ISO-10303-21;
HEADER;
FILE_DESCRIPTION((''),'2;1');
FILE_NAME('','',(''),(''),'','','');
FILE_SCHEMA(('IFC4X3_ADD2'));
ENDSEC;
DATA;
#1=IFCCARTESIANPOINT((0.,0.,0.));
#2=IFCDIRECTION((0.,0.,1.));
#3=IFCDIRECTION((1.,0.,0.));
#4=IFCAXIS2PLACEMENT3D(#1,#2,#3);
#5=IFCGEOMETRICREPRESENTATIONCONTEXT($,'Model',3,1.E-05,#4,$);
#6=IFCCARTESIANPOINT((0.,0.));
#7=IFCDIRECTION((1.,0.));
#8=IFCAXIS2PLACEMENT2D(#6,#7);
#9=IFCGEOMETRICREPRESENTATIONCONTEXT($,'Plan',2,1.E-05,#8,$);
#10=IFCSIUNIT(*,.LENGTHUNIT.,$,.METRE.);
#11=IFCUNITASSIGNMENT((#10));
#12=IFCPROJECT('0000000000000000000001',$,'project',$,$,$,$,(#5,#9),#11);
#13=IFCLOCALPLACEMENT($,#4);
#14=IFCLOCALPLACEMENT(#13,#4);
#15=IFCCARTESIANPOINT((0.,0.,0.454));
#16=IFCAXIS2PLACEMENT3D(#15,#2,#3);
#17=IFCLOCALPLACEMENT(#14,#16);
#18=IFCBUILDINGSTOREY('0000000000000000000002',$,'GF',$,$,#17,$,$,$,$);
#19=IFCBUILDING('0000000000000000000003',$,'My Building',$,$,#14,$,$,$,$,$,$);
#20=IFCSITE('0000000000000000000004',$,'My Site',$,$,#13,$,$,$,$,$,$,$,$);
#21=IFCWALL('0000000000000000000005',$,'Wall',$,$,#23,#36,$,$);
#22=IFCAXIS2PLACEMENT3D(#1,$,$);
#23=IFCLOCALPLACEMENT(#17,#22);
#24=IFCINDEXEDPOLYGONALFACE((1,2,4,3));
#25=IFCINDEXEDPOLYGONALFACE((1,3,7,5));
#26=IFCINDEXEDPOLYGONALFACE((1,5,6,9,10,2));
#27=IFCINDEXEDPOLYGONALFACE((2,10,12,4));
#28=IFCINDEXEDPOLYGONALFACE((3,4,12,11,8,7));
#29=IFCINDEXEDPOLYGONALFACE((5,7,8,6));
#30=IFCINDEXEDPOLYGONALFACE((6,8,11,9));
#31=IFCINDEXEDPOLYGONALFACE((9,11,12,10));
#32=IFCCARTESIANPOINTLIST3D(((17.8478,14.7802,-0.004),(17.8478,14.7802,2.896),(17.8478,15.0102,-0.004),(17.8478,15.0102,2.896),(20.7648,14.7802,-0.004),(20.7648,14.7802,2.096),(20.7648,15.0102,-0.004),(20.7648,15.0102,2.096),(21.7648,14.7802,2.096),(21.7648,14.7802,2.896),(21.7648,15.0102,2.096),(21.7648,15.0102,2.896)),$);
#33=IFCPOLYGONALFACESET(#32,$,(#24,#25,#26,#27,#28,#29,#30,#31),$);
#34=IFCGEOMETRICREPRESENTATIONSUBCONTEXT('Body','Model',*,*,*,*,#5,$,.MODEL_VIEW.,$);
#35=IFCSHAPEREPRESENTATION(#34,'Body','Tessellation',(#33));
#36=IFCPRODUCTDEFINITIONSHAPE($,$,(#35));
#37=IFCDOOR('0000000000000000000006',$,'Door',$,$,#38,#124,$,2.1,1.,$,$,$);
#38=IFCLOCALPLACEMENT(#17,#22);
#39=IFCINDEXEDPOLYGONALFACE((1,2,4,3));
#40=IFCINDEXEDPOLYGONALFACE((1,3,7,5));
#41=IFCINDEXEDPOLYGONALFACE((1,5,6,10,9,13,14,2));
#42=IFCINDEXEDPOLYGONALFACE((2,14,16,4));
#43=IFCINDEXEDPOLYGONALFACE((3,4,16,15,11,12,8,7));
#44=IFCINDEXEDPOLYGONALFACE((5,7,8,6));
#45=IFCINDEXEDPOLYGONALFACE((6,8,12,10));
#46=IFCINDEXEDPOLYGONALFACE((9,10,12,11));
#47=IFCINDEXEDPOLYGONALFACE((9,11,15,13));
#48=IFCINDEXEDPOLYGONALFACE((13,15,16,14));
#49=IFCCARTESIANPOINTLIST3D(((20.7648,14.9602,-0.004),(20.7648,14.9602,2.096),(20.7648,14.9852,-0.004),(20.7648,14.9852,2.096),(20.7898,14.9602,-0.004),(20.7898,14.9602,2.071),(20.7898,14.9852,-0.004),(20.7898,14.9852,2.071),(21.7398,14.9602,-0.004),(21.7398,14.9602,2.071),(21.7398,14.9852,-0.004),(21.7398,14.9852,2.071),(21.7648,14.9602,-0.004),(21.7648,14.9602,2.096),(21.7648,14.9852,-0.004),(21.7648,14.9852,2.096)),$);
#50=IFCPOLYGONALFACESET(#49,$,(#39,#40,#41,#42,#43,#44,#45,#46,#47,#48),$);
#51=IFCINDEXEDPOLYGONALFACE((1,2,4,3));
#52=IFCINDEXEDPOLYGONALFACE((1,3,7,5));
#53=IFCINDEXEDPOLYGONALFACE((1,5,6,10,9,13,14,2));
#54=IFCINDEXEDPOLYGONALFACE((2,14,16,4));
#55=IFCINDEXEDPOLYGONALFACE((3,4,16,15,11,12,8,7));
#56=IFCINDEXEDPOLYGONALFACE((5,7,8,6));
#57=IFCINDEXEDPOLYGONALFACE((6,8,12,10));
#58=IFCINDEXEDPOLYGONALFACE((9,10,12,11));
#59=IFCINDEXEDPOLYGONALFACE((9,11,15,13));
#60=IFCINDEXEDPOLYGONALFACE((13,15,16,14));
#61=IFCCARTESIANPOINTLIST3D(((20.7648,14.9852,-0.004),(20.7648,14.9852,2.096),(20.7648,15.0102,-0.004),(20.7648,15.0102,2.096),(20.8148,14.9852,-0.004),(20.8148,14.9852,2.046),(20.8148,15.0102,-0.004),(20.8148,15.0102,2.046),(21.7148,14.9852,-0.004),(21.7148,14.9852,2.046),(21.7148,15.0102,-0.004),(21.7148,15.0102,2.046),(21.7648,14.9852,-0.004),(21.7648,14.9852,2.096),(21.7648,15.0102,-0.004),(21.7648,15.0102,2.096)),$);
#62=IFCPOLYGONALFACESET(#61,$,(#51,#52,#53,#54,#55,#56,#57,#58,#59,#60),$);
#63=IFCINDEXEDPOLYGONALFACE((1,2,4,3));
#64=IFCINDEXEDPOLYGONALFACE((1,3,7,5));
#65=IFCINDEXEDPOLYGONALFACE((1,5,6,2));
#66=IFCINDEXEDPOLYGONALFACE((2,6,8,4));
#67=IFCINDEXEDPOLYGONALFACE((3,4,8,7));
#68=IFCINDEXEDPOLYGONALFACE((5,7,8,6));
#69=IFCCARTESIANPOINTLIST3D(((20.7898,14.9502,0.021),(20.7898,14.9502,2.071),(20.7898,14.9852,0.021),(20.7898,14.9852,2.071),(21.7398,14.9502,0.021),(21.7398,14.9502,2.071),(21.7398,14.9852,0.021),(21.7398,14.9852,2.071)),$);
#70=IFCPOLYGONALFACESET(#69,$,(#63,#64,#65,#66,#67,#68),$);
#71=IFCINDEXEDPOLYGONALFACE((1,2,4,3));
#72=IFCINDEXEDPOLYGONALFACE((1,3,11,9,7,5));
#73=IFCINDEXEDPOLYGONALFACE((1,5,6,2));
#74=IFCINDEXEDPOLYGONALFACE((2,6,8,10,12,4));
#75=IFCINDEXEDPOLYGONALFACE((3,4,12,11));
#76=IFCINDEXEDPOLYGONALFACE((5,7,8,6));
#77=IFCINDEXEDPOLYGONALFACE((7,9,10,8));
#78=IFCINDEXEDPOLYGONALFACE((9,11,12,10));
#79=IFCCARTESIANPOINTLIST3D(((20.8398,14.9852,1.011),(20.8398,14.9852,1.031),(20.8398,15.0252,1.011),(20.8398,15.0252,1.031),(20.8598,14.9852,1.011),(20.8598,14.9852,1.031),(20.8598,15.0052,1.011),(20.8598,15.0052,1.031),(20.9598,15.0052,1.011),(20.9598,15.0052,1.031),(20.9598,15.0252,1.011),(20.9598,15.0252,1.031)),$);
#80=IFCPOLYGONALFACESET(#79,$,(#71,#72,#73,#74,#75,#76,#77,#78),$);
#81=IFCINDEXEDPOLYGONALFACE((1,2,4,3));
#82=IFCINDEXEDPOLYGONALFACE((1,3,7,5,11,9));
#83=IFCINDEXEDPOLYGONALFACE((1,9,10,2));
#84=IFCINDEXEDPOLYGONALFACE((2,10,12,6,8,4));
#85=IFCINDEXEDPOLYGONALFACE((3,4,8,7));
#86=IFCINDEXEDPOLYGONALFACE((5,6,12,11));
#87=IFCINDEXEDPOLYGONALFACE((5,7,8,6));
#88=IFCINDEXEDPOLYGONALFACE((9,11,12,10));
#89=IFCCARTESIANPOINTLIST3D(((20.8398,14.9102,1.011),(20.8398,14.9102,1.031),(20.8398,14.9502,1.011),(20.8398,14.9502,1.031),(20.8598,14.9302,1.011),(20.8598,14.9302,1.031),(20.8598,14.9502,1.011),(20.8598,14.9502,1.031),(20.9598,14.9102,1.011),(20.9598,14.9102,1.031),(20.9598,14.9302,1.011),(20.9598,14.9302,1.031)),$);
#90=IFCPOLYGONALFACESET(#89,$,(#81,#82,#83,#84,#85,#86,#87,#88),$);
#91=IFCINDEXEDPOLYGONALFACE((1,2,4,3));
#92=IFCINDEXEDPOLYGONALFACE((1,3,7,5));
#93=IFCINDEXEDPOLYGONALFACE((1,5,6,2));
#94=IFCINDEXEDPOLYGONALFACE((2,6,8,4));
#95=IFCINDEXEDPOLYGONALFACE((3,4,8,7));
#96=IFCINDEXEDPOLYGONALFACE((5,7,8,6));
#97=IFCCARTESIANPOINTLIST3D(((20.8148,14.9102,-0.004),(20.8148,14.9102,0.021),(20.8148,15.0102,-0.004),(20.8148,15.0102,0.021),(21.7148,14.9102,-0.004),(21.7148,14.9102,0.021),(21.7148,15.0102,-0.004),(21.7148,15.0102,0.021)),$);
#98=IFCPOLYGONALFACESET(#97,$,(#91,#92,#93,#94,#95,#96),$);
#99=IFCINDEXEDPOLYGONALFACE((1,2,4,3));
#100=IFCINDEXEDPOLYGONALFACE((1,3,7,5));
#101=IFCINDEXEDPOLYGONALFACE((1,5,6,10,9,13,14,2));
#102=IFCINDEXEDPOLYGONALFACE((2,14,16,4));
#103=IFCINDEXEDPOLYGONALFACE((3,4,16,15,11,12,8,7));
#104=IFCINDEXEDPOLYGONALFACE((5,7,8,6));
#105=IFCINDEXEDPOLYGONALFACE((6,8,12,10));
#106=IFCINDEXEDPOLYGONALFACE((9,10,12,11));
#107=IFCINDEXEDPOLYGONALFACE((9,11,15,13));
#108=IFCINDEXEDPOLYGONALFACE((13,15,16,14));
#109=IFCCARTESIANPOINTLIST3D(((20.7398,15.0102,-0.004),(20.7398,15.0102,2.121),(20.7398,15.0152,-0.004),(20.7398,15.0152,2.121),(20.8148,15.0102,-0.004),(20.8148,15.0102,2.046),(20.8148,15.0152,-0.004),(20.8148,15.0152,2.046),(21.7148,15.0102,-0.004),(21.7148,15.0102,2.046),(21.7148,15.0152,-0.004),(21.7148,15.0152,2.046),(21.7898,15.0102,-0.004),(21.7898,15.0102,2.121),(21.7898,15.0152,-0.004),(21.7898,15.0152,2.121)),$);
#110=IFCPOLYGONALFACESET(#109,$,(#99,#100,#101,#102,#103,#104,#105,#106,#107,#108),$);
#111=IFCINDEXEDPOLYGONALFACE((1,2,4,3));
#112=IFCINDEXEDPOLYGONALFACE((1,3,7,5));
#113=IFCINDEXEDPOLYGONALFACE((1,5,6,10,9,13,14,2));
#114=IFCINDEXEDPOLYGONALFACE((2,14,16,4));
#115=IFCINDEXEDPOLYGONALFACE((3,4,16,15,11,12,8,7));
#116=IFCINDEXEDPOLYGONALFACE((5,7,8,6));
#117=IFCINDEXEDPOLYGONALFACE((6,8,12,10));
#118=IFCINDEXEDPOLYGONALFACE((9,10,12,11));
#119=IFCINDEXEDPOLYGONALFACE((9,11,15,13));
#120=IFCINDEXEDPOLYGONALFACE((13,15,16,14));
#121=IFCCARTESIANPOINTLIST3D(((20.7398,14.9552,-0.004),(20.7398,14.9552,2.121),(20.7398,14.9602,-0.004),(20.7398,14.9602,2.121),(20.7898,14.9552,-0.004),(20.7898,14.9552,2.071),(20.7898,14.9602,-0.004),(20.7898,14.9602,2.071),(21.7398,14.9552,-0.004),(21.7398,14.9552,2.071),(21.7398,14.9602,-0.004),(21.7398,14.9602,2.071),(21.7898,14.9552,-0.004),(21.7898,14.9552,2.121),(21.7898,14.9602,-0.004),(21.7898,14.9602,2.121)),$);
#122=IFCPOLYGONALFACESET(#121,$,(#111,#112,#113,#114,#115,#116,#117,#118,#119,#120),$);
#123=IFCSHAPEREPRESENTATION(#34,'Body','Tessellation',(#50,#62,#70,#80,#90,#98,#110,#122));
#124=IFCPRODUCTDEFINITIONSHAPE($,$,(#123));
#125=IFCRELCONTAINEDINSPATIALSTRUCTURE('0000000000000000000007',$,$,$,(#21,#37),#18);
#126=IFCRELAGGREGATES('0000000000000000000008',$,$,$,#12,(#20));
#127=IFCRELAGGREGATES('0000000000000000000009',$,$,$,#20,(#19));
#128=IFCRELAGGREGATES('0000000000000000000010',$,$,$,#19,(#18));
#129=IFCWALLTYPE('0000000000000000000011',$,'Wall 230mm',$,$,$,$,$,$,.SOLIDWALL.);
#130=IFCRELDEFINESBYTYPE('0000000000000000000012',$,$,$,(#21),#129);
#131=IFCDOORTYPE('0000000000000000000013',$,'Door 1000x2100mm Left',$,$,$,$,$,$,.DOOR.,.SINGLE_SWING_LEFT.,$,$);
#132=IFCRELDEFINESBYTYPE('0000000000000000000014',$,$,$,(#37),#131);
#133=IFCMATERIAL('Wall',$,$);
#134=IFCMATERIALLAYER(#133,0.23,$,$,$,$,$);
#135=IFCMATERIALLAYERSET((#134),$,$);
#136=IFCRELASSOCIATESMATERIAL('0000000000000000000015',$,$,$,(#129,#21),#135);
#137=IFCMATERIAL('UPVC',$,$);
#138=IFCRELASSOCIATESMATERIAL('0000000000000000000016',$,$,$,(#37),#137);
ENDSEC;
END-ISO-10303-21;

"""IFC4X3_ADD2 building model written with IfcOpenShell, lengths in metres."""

from ifc_helpers import new_model, entity, si_unit, frame, origin_with_axes, origin_2d_with_axis, place, context, subcontext, project, spatial, line, indexed_curve, outline, extrude, shape, source, transform, mapped, material, layer, layer_set, layer_usage, type_object, type_shapes, element, fill, save


model = new_model("IFC4X3_ADD2")

# Units and contexts
model_context = context("Model", 3, precision=1e-05, world=origin_with_axes())
plan_context = context("Plan", 2, precision=1e-05, world=origin_2d_with_axis())
body_context_1 = subcontext(model_context, "Body", "Model", "MODEL_VIEW")
body_context_2 = subcontext(plan_context, "Body", "Plan", "PLAN_VIEW")
ifc_project = project(units=[si_unit("LENGTHUNIT", "METRE")], contexts=[model_context, plan_context])

# Site, building, storey
site_placement = place(None, origin_with_axes())
site = spatial("IfcSite", under=ifc_project, at=site_placement, Name="My Site")
building_placement = place(site_placement, origin_with_axes())
building = spatial("IfcBuilding", under=site, at=building_placement, Name="My Building")
storey_placement = place(building_placement, frame((0.0, 0.0, 0.454), z_axis=(0.0, 0.0, 1.0), x_axis=(1.0, 0.0, 0.0)))
storey = spatial("IfcBuildingStorey", under=building, at=storey_placement, Name="GF")

# Shared definitions
ifc_material_1 = material(Name="Wall")
ifc_material_2 = material(Name="UPVC")

# Shared definitions
shared_shape_1 = source(origin_with_axes(), body_context_1, "Body", "SweptSolid", [
    extrude(outline(indexed_curve([(0.0, 0.0), (1.0, 0.0), (1.0, 2.1), (0.0, 2.1)], segments=[line(1, 2, 3, 4, 1)])), frame((0.0, -0.6, 0.0), z_axis=(0.0, -1.0, 0.0), x_axis=(1.0, 0.0, 0.0)), (0.0, 0.0, -1.0), 1.2),
])
door_type_1 = type_object("IfcDoorType", Name="Door 1000x2100mm Left", OperationType="SINGLE_SWING_LEFT", PredefinedType="DOOR")
shared_shape_2 = source(origin_with_axes(), body_context_1, "Body", "SweptSolid", [
    extrude(outline(indexed_curve([(0.0, 0.0), (0.0, 2.1), (1.0, 2.1), (1.0, 0.0), (0.975, 0.0), (0.975, 2.075), (0.025, 2.075), (0.025, 0.0)], segments=[line(1, 2, 3, 4, 5, 6, 7, 8, 1)])), frame((0.0, 0.025, 0.0), z_axis=(0.0, -1.0, 0.0), x_axis=(1.0, 0.0, 0.0)), (0.0, 0.0, -1.0), 0.025),
    extrude(outline(indexed_curve([(0.0, 0.0), (0.0, 2.1), (1.0, 2.1), (1.0, 0.0), (0.95, 0.0), (0.95, 2.05), (0.05, 2.05), (0.05, 0.0)], segments=[line(1, 2, 3, 4, 5, 6, 7, 8, 1)])), frame((0.0, 0.0, 0.0), z_axis=(0.0, -1.0, 0.0), x_axis=(1.0, 0.0, 0.0)), (0.0, 0.0, -1.0), 0.025),
    extrude(outline(indexed_curve([(0.0, 0.0), (0.95, 0.0), (0.95, 0.035), (0.0, 0.035)], segments=[line(1, 2, 3, 4, 1)])), frame((0.025, 0.025, 0.025), z_axis=(0.0, 0.0, 1.0), x_axis=(1.0, 0.0, 0.0)), (0.0, 0.0, 1.0), 2.05),
    extrude(outline(indexed_curve([(0.0, 0.0), (0.0, -0.04), (-0.12, -0.04), (-0.12, -0.02), (-0.02, -0.02), (-0.02, 0.0)], segments=[line(1, 2, 3, 4, 5, 6, 1)])), frame((0.925, 0.025, 1.015), z_axis=(0.0, 0.0, 1.0), x_axis=(1.0, 0.0, 0.0)), (0.0, 0.0, 1.0), 0.02),
    extrude(outline(indexed_curve([(0.0, 0.0), (0.0, 0.04), (-0.12, 0.04), (-0.12, 0.02), (-0.02, 0.02), (-0.02, 0.0)], segments=[line(1, 2, 3, 4, 5, 6, 1)])), frame((0.925, 0.06, 1.015), z_axis=(0.0, 0.0, 1.0), x_axis=(1.0, 0.0, 0.0)), (0.0, 0.0, 1.0), 0.02),
    extrude(outline(indexed_curve([(0.0, 0.0), (0.9, 0.0), (0.9, 0.1), (0.0, 0.1)], segments=[line(1, 2, 3, 4, 1)])), frame((0.05, 0.0, 0.0), z_axis=(0.0, 0.0, 1.0), x_axis=(1.0, 0.0, 0.0)), (0.0, 0.0, 1.0), 0.025),
    extrude(outline(indexed_curve([(0.0, 0.0), (0.0, 2.125), (1.05, 2.125), (1.05, 0.0), (0.975, 0.0), (0.975, 2.05), (0.075, 2.05), (0.075, 0.0)], segments=[line(1, 2, 3, 4, 5, 6, 7, 8, 1)])), frame((-0.025, -0.005, 0.0), z_axis=(0.0, -1.0, 0.0), x_axis=(1.0, 0.0, 0.0)), (0.0, 0.0, -1.0), 0.005),
    extrude(outline(indexed_curve([(0.0, 0.0), (0.0, 2.125), (1.05, 2.125), (1.05, 0.0), (1.0, 0.0), (1.0, 2.075), (0.05, 2.075), (0.05, 0.0)], segments=[line(1, 2, 3, 4, 5, 6, 7, 8, 1)])), frame((-0.025, 0.05, 0.0), z_axis=(0.0, -1.0, 0.0), x_axis=(1.0, 0.0, 0.0)), (0.0, 0.0, -1.0), 0.005),
])
shared_shape_3 = source(origin_with_axes(), body_context_2, "Body", "Curve2D", [
    entity("IfcIndexedPolyCurve", entity("IfcCartesianPointList2D", [[0.0, 0.0], [0.0, 0.05], [0.025, 0.05], [0.025, 0.025], [0.05, 0.025], [0.05, 0.0]]), [entity("IfcLineIndex", [1, 2, 3, 4, 5, 6, 1])]),
    entity("IfcIndexedPolyCurve", entity("IfcCartesianPointList2D", [[1.0, 0.0], [1.0, 0.05], [0.975, 0.05], [0.975, 0.025], [0.95, 0.025], [0.95, 0.0]]), [entity("IfcLineIndex", [1, 2, 3, 4, 5, 6, 1])]),
    entity("IfcTrimmedCurve", entity("IfcEllipse", entity("IfcAxis2Placement2D", entity("IfcCartesianPoint", [0.06, 0.05]), entity("IfcDirection", [1.0, 0.0])), 0.915, 0.95), [entity("IfcCartesianPoint", [0.975, 0.05])], [entity("IfcCartesianPoint", [0.06, 1.0])], True, "CARTESIAN"),
    entity("IfcIndexedPolyCurve", entity("IfcCartesianPointList2D", [[0.025, 0.05], [0.06, 0.05], [0.06, 1.0], [0.025, 1.0]]), [entity("IfcLineIndex", [1, 2, 3, 4, 1])]),
])
type_shapes(door_type_1, [shared_shape_2, shared_shape_3])

# Shared definitions
ifc_layer_1 = layer(ifc_material_1, 0.23)
ifc_layer_set_1 = layer_set([ifc_layer_1])
wall_type_1 = type_object("IfcWallType", Name="Wall 230mm", PredefinedType="SOLIDWALL", material=ifc_layer_set_1)

# Wall, opening, door
ifc_layer_usage_1 = layer_usage(ifc_layer_set_1, "AXIS2", "POSITIVE", 0.0)
wall_1_placement = place(storey_placement, frame((21.7648, 15.0102, -0.004), z_axis=(0.0, 0.0, 1.0), x_axis=(-1.0, 0.0, 0.0)))
wall_1 = element("IfcWall", 1, at=wall_1_placement, inside=storey, type_object=wall_type_1, material=ifc_layer_usage_1, Name="Wall", context=body_context_1, shape_type="SweptSolid", body=[
    extrude(outline(indexed_curve([(0.0, 0.0), (0.0, 0.23), (3.917, 0.23), (3.917, 0.0), (0.0, 0.0)], self_intersect=False)), origin_with_axes(), (0.0, 0.0, 1.0), 2.9),
])
opening_1_placement = place(wall_1_placement, frame((0.0, 0.0, 0.0), z_axis=(0.0, 0.0, 1.0), x_axis=(1.0, 0.0, 0.0)))
opening_1 = element("IfcOpeningElement", 2, at=opening_1_placement, cuts=wall_1, PredefinedType="OPENING", context=body_context_1, shape_type="MappedRepresentation", body=[
    mapped(shared_shape_1, transform((0.0, 0.0, 0.0), x_axis=(1.0, 0.0, 0.0), y_axis=(0.0, 1.0, 0.0), z_axis=(0.0, 0.0, 1.0), scale=1.0)),
])
door_1_placement = place(opening_1_placement, frame((0.0, 0.0, 0.0), z_axis=(0.0, 0.0, 1.0), x_axis=(1.0, 0.0, 0.0)))
door_1 = element("IfcDoor", 3, at=door_1_placement, inside=storey, type_object=door_type_1, material=ifc_material_2, Name="Door", OverallHeight=2.1, OverallWidth=1.0, shapes=[
    shape(body_context_1, "Body", "MappedRepresentation", [mapped(shared_shape_2, transform((0.0, 0.0, 0.0), x_axis=(1.0, 0.0, 0.0), y_axis=(0.0, 1.0, 0.0), z_axis=(0.0, 0.0, 1.0), scale=1.0))]),
    shape(body_context_2, "Body", "MappedRepresentation", [mapped(shared_shape_3, transform((0.0, 0.0, 0.0), x_axis=(1.0, 0.0, 0.0), y_axis=(0.0, 1.0, 0.0), z_axis=(0.0, 0.0, 1.0), scale=1.0))]),
])
fill(opening_1, door_1)

save(model, "model.ifc")
